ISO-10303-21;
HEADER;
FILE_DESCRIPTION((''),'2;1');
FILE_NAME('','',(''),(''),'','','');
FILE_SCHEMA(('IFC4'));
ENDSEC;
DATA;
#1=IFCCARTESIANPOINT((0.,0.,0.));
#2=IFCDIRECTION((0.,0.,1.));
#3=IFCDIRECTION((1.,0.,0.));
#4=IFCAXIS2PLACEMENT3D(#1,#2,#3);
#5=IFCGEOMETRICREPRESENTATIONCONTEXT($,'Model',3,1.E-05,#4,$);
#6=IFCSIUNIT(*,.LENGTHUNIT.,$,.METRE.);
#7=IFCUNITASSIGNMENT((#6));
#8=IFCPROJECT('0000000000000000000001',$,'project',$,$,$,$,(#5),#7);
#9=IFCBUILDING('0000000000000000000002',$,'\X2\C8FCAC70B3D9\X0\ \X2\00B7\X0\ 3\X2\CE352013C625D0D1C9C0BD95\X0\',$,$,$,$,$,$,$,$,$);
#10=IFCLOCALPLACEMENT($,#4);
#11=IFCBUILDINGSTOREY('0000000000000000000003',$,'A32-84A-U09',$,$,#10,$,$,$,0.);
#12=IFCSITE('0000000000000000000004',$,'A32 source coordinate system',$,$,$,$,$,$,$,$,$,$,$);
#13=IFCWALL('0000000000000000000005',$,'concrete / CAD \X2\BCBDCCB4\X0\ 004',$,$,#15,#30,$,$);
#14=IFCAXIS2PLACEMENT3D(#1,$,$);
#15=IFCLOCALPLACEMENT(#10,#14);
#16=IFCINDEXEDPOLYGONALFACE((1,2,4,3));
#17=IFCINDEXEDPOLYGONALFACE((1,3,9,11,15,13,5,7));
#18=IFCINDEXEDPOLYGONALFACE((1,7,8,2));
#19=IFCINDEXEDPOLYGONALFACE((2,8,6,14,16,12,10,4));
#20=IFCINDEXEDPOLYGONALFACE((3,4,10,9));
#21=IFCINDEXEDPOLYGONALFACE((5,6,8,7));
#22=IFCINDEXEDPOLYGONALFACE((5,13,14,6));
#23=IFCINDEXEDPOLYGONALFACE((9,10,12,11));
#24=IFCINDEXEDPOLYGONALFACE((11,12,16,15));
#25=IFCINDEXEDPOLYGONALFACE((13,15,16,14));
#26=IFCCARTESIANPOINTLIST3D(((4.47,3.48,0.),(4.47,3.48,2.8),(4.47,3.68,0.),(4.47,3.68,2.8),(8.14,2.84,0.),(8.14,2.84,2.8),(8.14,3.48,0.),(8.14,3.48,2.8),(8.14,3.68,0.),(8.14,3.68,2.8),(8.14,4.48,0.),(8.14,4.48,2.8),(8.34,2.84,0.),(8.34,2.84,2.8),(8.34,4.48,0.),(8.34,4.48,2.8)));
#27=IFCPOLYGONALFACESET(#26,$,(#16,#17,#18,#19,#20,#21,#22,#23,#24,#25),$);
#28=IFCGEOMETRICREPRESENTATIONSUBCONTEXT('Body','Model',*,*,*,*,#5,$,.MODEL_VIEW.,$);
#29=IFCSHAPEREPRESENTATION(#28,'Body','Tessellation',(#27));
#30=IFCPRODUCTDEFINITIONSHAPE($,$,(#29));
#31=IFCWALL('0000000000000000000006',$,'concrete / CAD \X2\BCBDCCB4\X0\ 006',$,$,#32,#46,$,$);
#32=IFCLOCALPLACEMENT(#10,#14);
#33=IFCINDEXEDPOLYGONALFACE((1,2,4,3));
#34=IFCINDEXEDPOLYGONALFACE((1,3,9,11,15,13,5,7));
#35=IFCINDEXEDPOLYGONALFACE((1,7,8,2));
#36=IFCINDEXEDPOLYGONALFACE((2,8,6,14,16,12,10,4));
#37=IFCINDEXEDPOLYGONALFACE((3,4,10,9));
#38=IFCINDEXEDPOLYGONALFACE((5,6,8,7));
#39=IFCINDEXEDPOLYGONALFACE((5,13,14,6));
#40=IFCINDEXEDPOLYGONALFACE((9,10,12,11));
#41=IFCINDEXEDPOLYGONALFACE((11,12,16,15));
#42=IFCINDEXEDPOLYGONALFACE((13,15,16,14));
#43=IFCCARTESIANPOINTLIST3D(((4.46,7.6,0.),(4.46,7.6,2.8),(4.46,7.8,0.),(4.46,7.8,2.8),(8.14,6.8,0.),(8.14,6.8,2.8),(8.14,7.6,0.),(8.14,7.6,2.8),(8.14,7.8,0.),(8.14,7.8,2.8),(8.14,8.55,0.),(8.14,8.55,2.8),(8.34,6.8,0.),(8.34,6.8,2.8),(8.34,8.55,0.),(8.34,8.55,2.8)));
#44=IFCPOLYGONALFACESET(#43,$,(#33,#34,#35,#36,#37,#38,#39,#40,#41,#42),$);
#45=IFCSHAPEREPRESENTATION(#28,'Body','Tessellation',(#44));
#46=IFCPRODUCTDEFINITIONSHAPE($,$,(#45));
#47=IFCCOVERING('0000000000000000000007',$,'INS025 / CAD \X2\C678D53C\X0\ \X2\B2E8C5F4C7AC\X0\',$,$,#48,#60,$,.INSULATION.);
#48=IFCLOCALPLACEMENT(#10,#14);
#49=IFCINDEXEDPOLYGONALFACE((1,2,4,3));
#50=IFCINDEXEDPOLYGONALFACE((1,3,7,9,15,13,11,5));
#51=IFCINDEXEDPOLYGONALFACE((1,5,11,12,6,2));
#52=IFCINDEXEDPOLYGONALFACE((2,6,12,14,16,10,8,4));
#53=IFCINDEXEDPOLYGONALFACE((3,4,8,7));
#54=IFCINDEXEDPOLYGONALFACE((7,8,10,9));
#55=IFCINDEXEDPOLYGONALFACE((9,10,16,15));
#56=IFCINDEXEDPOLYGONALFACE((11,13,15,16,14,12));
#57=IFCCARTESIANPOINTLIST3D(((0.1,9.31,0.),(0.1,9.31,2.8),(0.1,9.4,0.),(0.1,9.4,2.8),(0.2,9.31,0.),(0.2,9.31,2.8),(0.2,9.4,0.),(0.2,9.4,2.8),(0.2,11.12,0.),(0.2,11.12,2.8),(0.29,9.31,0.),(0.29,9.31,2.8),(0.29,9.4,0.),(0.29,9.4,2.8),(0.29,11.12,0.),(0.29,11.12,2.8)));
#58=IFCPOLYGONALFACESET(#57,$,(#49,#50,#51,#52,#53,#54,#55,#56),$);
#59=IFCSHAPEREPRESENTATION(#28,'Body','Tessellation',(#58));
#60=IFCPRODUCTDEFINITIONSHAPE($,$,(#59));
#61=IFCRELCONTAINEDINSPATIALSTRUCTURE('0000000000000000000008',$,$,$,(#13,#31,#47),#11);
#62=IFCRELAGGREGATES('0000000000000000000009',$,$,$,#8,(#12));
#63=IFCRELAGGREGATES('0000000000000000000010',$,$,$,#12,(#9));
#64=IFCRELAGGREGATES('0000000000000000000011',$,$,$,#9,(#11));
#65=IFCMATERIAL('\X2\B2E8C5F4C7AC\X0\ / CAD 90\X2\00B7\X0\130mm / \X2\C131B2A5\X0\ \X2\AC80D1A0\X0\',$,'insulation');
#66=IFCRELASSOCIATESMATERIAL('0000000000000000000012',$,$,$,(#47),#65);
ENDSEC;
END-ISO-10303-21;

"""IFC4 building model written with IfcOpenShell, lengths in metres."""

from ifc_helpers import new_model, si_unit, origin, origin_with_axes, place, context, subcontext, project, spatial, polyline, outline, extrude, material, element, save


model = new_model("IFC4")

# Units and contexts
model_context = context("Model", 3, precision=1e-05, world=origin_with_axes())
body_context = subcontext(model_context, "Body", "Model", "MODEL_VIEW")
ifc_project = project(units=[si_unit("LENGTHUNIT", "METRE")], contexts=[model_context])

# Site, building, storey
storey_placement = place(None, origin_with_axes())
site = spatial("IfcSite", under=ifc_project, Name="A32 source coordinate system")
building = spatial("IfcBuilding", under=site, Name="주거동 · 3층–옥탑지붕")
storey = spatial("IfcBuildingStorey", under=building, at=storey_placement, Name="A32-84A-U09", Elevation=0.0)

# Walls
wall_1_placement = place(storey_placement, origin_with_axes())
element("IfcWall", 1, at=wall_1_placement, inside=storey, Name="concrete / CAD 벽체 004", context=body_context, shape_type="SweptSolid", body=[
    extrude(outline(polyline([(8.14, 3.68), (8.14, 4.48), (8.34, 4.48), (8.34, 2.84), (8.14, 2.84), (8.14, 3.48), (4.47, 3.48), (4.47, 3.68), (8.14, 3.68)])), origin(), (0.0, 0.0, 1.0), 2.8),
])
wall_2_placement = place(storey_placement, origin_with_axes())
element("IfcWall", 2, at=wall_2_placement, inside=storey, Name="concrete / CAD 벽체 006", context=body_context, shape_type="SweptSolid", body=[
    extrude(outline(polyline([(8.14, 7.8), (8.14, 8.55), (8.34, 8.55), (8.34, 6.8), (8.14, 6.8), (8.14, 7.6), (4.46, 7.6), (4.46, 7.8), (8.14, 7.8)])), origin(), (0.0, 0.0, 1.0), 2.8),
])

# Covering
ifc_material = material(Name="단열재 / CAD 90·130mm / 성능 검토", Category="insulation")
covering_placement = place(storey_placement, origin_with_axes())
element("IfcCovering", 3, at=covering_placement, inside=storey, material=ifc_material, Name="INS025 / CAD 외피 단열재", PredefinedType="INSULATION", context=body_context, shape_type="SweptSolid", body=[
    extrude(outline(polyline([(0.2, 9.4), (0.2, 11.12), (0.29, 11.12), (0.29, 9.4), (0.29, 9.31), (0.2, 9.31), (0.1, 9.31), (0.1, 9.4), (0.2, 9.4)])), origin(), (0.0, 0.0, 1.0), 2.8),
])

save(model, "model.ifc")
